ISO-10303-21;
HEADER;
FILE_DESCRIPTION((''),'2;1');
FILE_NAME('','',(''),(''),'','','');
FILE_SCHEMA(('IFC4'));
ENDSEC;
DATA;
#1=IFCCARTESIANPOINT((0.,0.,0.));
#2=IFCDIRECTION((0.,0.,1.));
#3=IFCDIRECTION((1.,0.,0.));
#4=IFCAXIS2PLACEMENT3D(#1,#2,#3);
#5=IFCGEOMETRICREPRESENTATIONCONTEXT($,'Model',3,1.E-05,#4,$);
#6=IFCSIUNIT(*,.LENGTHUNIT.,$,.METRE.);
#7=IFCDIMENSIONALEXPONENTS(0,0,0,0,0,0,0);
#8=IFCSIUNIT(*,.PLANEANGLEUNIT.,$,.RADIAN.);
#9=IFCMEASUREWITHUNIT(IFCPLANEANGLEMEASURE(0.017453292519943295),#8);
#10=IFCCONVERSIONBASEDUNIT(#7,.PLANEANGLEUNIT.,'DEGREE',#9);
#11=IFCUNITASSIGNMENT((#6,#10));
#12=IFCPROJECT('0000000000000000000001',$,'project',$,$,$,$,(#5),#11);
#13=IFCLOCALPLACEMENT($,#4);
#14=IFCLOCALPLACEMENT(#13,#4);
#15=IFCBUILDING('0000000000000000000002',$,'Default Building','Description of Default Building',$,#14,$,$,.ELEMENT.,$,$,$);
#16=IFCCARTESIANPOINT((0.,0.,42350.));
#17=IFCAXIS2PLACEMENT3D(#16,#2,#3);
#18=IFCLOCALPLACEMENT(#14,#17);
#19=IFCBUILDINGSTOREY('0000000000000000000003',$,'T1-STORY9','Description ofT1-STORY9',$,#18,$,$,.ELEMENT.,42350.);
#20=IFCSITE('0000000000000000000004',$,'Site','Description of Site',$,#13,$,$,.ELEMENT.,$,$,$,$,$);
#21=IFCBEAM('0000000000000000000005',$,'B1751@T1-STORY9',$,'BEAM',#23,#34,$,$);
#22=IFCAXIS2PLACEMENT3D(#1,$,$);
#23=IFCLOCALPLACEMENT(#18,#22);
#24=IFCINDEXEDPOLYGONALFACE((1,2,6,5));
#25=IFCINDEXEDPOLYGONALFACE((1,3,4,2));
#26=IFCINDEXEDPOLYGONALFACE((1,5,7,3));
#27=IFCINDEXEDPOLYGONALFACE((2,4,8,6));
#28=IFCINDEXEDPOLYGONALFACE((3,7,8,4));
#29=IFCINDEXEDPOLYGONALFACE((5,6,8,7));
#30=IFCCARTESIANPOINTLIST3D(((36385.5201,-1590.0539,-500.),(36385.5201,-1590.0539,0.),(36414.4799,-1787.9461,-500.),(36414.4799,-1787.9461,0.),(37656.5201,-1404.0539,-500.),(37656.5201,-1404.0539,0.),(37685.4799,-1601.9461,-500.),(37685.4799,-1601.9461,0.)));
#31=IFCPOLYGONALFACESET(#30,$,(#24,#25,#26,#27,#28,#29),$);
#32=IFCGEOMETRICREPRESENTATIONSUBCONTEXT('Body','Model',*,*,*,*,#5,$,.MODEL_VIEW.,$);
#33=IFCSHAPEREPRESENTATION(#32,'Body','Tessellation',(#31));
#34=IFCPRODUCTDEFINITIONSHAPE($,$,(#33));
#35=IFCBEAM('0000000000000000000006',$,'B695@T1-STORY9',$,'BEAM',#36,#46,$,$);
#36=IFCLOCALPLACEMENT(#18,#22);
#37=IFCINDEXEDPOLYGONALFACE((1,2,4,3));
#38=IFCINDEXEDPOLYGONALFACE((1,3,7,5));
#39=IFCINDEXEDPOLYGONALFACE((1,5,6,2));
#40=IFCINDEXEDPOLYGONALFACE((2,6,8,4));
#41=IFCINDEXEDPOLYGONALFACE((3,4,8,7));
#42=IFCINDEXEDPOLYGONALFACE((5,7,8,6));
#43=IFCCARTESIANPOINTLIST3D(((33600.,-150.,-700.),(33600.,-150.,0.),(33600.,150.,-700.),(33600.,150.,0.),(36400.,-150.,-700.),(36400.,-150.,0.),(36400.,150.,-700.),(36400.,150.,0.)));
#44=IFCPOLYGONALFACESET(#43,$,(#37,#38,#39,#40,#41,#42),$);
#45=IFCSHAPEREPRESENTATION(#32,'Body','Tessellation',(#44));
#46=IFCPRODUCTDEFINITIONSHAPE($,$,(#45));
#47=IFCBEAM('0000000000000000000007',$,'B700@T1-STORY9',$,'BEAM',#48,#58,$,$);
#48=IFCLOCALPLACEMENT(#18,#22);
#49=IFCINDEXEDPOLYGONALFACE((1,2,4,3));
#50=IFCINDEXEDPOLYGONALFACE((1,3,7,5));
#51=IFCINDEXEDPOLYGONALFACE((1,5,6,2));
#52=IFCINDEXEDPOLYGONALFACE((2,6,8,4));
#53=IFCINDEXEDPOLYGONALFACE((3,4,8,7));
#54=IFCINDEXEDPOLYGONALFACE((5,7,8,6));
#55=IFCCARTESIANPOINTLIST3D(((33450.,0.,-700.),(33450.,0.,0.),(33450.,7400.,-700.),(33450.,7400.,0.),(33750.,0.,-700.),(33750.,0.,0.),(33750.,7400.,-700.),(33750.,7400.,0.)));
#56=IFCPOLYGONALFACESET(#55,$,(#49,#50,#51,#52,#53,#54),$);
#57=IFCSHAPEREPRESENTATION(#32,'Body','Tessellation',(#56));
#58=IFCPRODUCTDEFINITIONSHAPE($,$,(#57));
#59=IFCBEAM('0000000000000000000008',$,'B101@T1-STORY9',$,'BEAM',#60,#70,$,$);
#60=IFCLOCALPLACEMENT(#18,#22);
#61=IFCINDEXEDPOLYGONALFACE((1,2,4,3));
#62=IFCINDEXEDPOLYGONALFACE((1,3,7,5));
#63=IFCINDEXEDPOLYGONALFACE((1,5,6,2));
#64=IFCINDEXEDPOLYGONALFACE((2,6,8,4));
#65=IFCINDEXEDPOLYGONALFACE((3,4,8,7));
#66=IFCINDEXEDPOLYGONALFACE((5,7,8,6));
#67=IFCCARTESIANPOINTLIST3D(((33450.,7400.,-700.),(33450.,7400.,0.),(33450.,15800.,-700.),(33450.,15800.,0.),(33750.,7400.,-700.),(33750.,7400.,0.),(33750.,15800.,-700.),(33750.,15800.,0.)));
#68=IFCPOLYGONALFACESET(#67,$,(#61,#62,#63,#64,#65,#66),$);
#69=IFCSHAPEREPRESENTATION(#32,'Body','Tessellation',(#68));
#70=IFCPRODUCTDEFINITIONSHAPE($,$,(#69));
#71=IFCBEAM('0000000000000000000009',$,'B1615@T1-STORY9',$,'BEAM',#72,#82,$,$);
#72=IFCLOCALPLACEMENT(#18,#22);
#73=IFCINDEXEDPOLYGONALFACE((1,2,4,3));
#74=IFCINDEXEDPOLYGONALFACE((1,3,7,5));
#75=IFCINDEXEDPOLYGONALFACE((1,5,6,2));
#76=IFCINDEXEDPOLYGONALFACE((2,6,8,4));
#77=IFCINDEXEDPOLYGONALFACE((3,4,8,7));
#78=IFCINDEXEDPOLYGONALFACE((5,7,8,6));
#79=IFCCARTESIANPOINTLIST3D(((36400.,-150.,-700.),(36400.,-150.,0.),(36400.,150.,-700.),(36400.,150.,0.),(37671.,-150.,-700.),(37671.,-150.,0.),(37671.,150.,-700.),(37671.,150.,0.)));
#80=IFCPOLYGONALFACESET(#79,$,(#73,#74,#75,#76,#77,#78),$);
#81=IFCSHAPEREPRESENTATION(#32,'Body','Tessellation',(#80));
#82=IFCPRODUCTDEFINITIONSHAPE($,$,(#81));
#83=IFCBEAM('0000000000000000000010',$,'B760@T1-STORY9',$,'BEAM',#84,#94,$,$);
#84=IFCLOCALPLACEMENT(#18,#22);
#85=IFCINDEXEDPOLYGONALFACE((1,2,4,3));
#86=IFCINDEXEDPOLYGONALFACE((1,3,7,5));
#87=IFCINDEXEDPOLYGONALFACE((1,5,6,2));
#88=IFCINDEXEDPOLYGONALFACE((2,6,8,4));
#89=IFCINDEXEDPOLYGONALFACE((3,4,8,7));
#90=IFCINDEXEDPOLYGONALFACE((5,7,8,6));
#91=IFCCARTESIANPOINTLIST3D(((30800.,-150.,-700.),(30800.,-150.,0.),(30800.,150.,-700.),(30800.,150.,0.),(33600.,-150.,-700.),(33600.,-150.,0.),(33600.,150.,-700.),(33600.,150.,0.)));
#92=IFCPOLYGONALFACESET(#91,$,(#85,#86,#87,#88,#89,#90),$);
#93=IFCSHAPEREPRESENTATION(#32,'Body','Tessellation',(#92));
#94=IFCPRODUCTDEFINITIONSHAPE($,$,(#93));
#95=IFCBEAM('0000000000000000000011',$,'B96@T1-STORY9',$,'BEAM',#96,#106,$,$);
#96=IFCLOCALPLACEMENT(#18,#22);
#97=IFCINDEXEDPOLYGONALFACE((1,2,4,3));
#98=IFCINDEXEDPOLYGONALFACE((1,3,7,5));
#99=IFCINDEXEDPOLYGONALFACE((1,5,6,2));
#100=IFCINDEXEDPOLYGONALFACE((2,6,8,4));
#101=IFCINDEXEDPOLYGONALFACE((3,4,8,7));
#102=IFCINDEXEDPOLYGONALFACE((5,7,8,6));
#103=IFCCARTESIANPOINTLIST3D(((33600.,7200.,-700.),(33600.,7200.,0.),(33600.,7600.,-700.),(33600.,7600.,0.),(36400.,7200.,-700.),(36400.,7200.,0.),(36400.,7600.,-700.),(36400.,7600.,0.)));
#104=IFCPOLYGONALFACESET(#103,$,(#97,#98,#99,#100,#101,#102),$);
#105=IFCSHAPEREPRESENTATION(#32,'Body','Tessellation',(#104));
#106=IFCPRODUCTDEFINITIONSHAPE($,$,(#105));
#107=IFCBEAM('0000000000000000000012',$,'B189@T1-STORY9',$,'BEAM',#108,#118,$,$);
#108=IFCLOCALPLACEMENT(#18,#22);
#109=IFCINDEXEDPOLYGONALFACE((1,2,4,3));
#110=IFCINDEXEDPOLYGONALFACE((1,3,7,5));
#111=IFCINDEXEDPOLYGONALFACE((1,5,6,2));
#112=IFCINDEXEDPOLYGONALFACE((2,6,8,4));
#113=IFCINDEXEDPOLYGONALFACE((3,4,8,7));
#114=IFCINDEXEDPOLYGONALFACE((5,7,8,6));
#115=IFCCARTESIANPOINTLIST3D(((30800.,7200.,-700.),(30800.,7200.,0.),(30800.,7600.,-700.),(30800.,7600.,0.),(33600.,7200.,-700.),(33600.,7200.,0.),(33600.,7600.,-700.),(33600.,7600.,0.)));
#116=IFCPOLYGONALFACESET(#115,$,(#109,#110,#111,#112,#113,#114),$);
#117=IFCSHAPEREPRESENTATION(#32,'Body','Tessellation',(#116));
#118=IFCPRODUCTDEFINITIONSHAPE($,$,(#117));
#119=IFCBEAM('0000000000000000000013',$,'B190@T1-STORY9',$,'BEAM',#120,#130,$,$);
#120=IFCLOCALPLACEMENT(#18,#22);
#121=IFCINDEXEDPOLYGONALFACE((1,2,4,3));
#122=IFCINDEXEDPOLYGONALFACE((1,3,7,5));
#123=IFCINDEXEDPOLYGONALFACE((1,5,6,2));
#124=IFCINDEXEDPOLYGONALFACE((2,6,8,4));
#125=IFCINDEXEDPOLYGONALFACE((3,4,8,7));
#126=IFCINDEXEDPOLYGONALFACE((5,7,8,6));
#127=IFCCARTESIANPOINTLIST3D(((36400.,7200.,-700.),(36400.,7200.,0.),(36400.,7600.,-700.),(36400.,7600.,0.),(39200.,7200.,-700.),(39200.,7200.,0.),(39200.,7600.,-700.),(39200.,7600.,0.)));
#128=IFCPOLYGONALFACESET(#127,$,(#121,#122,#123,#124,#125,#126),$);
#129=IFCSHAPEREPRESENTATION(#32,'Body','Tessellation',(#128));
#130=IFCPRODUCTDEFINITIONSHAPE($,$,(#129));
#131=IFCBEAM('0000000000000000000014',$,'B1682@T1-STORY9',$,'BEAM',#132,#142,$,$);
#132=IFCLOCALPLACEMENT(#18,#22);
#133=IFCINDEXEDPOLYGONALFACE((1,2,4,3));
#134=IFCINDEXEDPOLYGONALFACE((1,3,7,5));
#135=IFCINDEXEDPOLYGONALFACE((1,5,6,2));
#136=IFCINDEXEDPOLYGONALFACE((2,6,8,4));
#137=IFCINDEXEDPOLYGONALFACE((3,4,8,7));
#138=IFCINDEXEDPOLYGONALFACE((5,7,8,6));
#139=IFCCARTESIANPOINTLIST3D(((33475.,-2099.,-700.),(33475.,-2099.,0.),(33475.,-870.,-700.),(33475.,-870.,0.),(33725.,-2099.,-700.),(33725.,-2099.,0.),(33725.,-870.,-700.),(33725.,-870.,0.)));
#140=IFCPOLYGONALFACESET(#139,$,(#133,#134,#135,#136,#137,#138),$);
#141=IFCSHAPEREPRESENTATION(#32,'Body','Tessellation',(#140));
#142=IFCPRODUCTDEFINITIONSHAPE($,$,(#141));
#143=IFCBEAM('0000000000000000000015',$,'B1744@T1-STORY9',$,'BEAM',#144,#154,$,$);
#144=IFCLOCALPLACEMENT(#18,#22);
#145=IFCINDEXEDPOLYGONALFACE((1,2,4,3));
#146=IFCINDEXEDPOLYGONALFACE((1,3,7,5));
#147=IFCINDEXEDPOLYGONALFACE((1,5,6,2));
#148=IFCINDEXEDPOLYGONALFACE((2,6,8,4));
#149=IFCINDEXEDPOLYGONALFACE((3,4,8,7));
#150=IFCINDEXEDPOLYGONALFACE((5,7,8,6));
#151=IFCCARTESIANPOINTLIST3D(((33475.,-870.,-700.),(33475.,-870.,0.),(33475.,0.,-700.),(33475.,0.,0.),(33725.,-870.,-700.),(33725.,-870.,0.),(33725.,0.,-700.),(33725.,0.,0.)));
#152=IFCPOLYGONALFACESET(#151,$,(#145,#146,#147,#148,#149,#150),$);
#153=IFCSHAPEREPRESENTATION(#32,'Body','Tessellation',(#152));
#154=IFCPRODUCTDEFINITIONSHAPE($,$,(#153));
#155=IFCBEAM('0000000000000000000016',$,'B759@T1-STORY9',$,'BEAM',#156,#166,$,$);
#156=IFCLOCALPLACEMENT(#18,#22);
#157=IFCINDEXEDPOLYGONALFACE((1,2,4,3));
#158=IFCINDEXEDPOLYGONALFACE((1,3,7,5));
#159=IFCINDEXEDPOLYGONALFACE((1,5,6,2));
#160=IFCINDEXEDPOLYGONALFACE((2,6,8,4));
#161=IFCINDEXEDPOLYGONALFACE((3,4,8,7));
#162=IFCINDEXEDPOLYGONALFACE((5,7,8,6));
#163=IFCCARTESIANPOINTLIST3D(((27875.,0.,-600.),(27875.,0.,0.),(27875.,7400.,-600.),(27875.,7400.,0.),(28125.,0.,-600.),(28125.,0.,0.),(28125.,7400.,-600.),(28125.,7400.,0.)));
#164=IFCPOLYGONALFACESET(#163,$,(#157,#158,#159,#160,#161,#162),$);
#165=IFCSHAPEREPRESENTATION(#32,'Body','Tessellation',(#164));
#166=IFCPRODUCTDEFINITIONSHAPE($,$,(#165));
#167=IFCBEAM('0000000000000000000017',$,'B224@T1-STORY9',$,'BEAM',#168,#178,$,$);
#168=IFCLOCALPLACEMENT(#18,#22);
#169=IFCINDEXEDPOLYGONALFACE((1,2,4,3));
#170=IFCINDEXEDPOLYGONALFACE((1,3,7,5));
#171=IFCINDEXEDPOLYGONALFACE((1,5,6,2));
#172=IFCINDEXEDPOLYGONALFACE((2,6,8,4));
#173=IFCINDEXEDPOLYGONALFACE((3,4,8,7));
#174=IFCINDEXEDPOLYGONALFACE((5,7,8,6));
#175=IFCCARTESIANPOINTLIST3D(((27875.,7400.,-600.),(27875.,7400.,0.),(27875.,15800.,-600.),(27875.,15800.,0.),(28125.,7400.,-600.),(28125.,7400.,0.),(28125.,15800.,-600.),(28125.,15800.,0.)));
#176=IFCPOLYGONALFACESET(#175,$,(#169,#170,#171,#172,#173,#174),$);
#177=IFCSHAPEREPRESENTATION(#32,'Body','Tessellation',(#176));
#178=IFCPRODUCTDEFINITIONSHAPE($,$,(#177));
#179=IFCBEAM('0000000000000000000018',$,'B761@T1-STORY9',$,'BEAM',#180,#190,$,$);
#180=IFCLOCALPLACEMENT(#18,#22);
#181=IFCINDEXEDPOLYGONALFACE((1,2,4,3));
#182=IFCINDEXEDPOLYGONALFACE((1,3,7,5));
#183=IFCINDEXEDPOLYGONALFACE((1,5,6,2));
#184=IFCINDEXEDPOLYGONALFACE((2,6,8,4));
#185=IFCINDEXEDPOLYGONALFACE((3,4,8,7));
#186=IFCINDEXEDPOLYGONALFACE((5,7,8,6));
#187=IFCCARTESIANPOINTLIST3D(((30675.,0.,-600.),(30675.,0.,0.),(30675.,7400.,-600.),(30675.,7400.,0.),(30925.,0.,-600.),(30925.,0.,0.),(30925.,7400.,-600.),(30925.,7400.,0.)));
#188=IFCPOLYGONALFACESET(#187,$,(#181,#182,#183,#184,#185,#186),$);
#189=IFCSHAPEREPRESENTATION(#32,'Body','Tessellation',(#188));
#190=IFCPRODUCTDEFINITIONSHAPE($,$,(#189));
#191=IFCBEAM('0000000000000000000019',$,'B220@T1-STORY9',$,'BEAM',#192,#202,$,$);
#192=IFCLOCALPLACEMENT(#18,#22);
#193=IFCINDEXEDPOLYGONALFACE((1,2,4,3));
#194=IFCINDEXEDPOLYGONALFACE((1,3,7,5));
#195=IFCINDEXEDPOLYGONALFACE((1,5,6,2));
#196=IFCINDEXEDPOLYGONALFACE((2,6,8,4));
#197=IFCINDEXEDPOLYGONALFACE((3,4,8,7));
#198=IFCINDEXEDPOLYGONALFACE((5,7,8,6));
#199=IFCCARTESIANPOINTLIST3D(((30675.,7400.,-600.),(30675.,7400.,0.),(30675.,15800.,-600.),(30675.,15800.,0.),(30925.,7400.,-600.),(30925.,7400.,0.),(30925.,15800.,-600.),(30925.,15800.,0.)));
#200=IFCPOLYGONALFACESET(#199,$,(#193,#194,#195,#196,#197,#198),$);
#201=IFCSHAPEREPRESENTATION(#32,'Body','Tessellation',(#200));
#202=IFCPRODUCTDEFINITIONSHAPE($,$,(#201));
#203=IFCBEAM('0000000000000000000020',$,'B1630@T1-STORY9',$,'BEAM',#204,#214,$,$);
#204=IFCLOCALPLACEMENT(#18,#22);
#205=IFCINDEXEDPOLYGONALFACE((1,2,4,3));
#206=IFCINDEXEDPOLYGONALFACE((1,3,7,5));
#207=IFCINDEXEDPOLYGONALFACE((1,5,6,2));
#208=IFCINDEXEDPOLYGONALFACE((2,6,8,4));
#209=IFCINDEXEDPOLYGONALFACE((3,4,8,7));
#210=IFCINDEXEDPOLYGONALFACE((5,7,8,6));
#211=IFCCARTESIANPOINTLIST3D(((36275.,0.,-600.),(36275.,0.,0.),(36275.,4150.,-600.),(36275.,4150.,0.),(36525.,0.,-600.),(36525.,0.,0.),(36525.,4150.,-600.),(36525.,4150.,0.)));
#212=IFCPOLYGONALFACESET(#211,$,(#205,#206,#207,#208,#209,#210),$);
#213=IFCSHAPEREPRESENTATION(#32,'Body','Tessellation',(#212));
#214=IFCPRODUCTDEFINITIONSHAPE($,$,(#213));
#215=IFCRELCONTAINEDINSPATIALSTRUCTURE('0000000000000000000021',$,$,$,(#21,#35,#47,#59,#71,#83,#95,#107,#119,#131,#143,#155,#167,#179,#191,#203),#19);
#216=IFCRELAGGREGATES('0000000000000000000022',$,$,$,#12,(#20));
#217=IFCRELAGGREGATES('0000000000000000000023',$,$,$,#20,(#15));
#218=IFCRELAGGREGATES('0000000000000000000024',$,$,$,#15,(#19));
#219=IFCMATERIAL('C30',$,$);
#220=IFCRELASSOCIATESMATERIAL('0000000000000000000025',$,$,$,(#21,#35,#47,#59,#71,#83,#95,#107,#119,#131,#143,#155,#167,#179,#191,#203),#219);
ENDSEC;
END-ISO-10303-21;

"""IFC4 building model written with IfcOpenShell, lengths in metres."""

from ifc_helpers import new_model, entity, si_unit, converted_unit, frame, origin_with_axes, place, context, subcontext, project, spatial, rectangle, extrude, material, element, save


model = new_model("IFC4")

# Units and contexts
model_context = context("Model", 3, precision=1e-05, world=origin_with_axes())
body_context = subcontext(model_context, "Body", "Model", "MODEL_VIEW")
ifc_project = project(units=[si_unit("LENGTHUNIT", "METRE"), converted_unit("PLANEANGLEUNIT", "DEGREE", entity("IfcPlaneAngleMeasure", 0.017453292519943295), si_unit("PLANEANGLEUNIT", "RADIAN"), dimensions=[0, 0, 0, 0, 0, 0, 0])], contexts=[model_context])

# Site, building, storey
site_placement = place(None, origin_with_axes())
site = spatial("IfcSite", under=ifc_project, at=site_placement, Name="Site", Description="Description of Site", CompositionType="ELEMENT")
building_placement = place(site_placement, origin_with_axes())
building = spatial("IfcBuilding", under=site, at=building_placement, Name="Default Building", Description="Description of Default Building", CompositionType="ELEMENT")
storey_placement = place(building_placement, frame((0.0, 0.0, 42350.0), z_axis=(0.0, 0.0, 1.0), x_axis=(1.0, 0.0, 0.0)))
storey = spatial("IfcBuildingStorey", under=building, at=storey_placement, Name="T1-STORY9", Description="Description ofT1-STORY9", CompositionType="ELEMENT", Elevation=42350.0)

# Beams
ifc_material_1 = material(Name="C30")
beam_1_placement = place(storey_placement, frame((36400.0, -1689.0, -250.0), z_axis=(0.989461, 0.144799, 0.0), x_axis=(-0.144799, 0.989461, 0.0)))
element("IfcBeam", 1, at=beam_1_placement, inside=storey, material=ifc_material_1, Name="B1751@T1-STORY9", ObjectType="BEAM", context=body_context, shape_type="SweptSolid", body=[
    extrude(rectangle(XDim=200.0, YDim=500.0), origin_with_axes(), (0.0, 0.0, 1.0), 1284.5377),
])
beam_2_placement = place(storey_placement, frame((33600.0, 0.0, -350.0), z_axis=(1.0, 0.0, 0.0), x_axis=(0.0, 1.0, 0.0)))
element("IfcBeam", 2, at=beam_2_placement, inside=storey, material=ifc_material_1, Name="B695@T1-STORY9", ObjectType="BEAM", context=body_context, shape_type="SweptSolid", body=[
    extrude(rectangle(XDim=300.0, YDim=700.0), origin_with_axes(), (0.0, 0.0, 1.0), 2800.0),
])
beam_3_placement = place(storey_placement, frame((33600.0, 0.0, -350.0), z_axis=(0.0, 1.0, 0.0), x_axis=(-1.0, 0.0, 0.0)))
element("IfcBeam", 3, at=beam_3_placement, inside=storey, material=ifc_material_1, Name="B700@T1-STORY9", ObjectType="BEAM", context=body_context, shape_type="SweptSolid", body=[
    extrude(rectangle(XDim=300.0, YDim=700.0), origin_with_axes(), (0.0, 0.0, 1.0), 7400.0),
])
beam_4_placement = place(storey_placement, frame((33600.0, 7400.0, -350.0), z_axis=(0.0, 1.0, 0.0), x_axis=(-1.0, 0.0, 0.0)))
element("IfcBeam", 4, at=beam_4_placement, inside=storey, material=ifc_material_1, Name="B101@T1-STORY9", ObjectType="BEAM", context=body_context, shape_type="SweptSolid", body=[
    extrude(rectangle(XDim=300.0, YDim=700.0), origin_with_axes(), (0.0, 0.0, 1.0), 8400.0),
])
beam_5_placement = place(storey_placement, frame((36400.0, 0.0, -350.0), z_axis=(1.0, 0.0, 0.0), x_axis=(0.0, 1.0, 0.0)))
element("IfcBeam", 5, at=beam_5_placement, inside=storey, material=ifc_material_1, Name="B1615@T1-STORY9", ObjectType="BEAM", context=body_context, shape_type="SweptSolid", body=[
    extrude(rectangle(XDim=300.0, YDim=700.0), origin_with_axes(), (0.0, 0.0, 1.0), 1271.0),
])
beam_6_placement = place(storey_placement, frame((30800.0, 0.0, -350.0), z_axis=(1.0, 0.0, 0.0), x_axis=(0.0, 1.0, 0.0)))
element("IfcBeam", 6, at=beam_6_placement, inside=storey, material=ifc_material_1, Name="B760@T1-STORY9", ObjectType="BEAM", context=body_context, shape_type="SweptSolid", body=[
    extrude(rectangle(XDim=300.0, YDim=700.0), origin_with_axes(), (0.0, 0.0, 1.0), 2800.0),
])
for number, where, z_axis, x_axis, name in (
    (7, (33600.0, 7400.0, -350.0), (1.0, 0.0, 0.0), (0.0, 1.0, 0.0), "B96@T1-STORY9"),
    (8, (30800.0, 7400.0, -350.0), (1.0, 0.0, 0.0), (0.0, 1.0, 0.0), "B189@T1-STORY9"),
    (9, (36400.0, 7400.0, -350.0), (1.0, 0.0, 0.0), (0.0, 1.0, 0.0), "B190@T1-STORY9"),
):
    element("IfcBeam", number, at=place(storey_placement, frame(where, z_axis=z_axis, x_axis=x_axis)), inside=storey, material=ifc_material_1, Name=name, ObjectType="BEAM", context=body_context, shape_type="SweptSolid", body=[
        extrude(rectangle(XDim=400.0, YDim=700.0), origin_with_axes(), (0.0, 0.0, 1.0), 2800.0),
    ])
beam_7_placement = place(storey_placement, frame((33600.0, -2099.0, -350.0), z_axis=(0.0, 1.0, 0.0), x_axis=(-1.0, 0.0, 0.0)))
element("IfcBeam", 10, at=beam_7_placement, inside=storey, material=ifc_material_1, Name="B1682@T1-STORY9", ObjectType="BEAM", context=body_context, shape_type="SweptSolid", body=[
    extrude(rectangle(XDim=250.0, YDim=700.0), origin_with_axes(), (0.0, 0.0, 1.0), 1229.0),
])
beam_8_placement = place(storey_placement, frame((33600.0, -870.0, -350.0), z_axis=(0.0, 1.0, 0.0), x_axis=(-1.0, 0.0, 0.0)))
element("IfcBeam", 11, at=beam_8_placement, inside=storey, material=ifc_material_1, Name="B1744@T1-STORY9", ObjectType="BEAM", context=body_context, shape_type="SweptSolid", body=[
    extrude(rectangle(XDim=250.0, YDim=700.0), origin_with_axes(), (0.0, 0.0, 1.0), 870.0),
])
beam_9_placement = place(storey_placement, frame((28000.0, 0.0, -300.0), z_axis=(0.0, 1.0, 0.0), x_axis=(-1.0, 0.0, 0.0)))
element("IfcBeam", 12, at=beam_9_placement, inside=storey, material=ifc_material_1, Name="B759@T1-STORY9", ObjectType="BEAM", context=body_context, shape_type="SweptSolid", body=[
    extrude(rectangle(XDim=250.0, YDim=600.0), origin_with_axes(), (0.0, 0.0, 1.0), 7400.0),
])
beam_10_placement = place(storey_placement, frame((28000.0, 7400.0, -300.0), z_axis=(0.0, 1.0, 0.0), x_axis=(-1.0, 0.0, 0.0)))
element("IfcBeam", 13, at=beam_10_placement, inside=storey, material=ifc_material_1, Name="B224@T1-STORY9", ObjectType="BEAM", context=body_context, shape_type="SweptSolid", body=[
    extrude(rectangle(XDim=250.0, YDim=600.0), origin_with_axes(), (0.0, 0.0, 1.0), 8400.0),
])
beam_11_placement = place(storey_placement, frame((30800.0, 0.0, -300.0), z_axis=(0.0, 1.0, 0.0), x_axis=(-1.0, 0.0, 0.0)))
element("IfcBeam", 14, at=beam_11_placement, inside=storey, material=ifc_material_1, Name="B761@T1-STORY9", ObjectType="BEAM", context=body_context, shape_type="SweptSolid", body=[
    extrude(rectangle(XDim=250.0, YDim=600.0), origin_with_axes(), (0.0, 0.0, 1.0), 7400.0),
])
beam_12_placement = place(storey_placement, frame((30800.0, 7400.0, -300.0), z_axis=(0.0, 1.0, 0.0), x_axis=(-1.0, 0.0, 0.0)))
element("IfcBeam", 15, at=beam_12_placement, inside=storey, material=ifc_material_1, Name="B220@T1-STORY9", ObjectType="BEAM", context=body_context, shape_type="SweptSolid", body=[
    extrude(rectangle(XDim=250.0, YDim=600.0), origin_with_axes(), (0.0, 0.0, 1.0), 8400.0),
])
beam_13_placement = place(storey_placement, frame((36400.0, 0.0, -300.0), z_axis=(0.0, 1.0, 0.0), x_axis=(-1.0, 0.0, 0.0)))
element("IfcBeam", 16, at=beam_13_placement, inside=storey, material=ifc_material_1, Name="B1630@T1-STORY9", ObjectType="BEAM", context=body_context, shape_type="SweptSolid", body=[
    extrude(rectangle(XDim=250.0, YDim=600.0), origin_with_axes(), (0.0, 0.0, 1.0), 4150.0),
])

save(model, "model.ifc")
